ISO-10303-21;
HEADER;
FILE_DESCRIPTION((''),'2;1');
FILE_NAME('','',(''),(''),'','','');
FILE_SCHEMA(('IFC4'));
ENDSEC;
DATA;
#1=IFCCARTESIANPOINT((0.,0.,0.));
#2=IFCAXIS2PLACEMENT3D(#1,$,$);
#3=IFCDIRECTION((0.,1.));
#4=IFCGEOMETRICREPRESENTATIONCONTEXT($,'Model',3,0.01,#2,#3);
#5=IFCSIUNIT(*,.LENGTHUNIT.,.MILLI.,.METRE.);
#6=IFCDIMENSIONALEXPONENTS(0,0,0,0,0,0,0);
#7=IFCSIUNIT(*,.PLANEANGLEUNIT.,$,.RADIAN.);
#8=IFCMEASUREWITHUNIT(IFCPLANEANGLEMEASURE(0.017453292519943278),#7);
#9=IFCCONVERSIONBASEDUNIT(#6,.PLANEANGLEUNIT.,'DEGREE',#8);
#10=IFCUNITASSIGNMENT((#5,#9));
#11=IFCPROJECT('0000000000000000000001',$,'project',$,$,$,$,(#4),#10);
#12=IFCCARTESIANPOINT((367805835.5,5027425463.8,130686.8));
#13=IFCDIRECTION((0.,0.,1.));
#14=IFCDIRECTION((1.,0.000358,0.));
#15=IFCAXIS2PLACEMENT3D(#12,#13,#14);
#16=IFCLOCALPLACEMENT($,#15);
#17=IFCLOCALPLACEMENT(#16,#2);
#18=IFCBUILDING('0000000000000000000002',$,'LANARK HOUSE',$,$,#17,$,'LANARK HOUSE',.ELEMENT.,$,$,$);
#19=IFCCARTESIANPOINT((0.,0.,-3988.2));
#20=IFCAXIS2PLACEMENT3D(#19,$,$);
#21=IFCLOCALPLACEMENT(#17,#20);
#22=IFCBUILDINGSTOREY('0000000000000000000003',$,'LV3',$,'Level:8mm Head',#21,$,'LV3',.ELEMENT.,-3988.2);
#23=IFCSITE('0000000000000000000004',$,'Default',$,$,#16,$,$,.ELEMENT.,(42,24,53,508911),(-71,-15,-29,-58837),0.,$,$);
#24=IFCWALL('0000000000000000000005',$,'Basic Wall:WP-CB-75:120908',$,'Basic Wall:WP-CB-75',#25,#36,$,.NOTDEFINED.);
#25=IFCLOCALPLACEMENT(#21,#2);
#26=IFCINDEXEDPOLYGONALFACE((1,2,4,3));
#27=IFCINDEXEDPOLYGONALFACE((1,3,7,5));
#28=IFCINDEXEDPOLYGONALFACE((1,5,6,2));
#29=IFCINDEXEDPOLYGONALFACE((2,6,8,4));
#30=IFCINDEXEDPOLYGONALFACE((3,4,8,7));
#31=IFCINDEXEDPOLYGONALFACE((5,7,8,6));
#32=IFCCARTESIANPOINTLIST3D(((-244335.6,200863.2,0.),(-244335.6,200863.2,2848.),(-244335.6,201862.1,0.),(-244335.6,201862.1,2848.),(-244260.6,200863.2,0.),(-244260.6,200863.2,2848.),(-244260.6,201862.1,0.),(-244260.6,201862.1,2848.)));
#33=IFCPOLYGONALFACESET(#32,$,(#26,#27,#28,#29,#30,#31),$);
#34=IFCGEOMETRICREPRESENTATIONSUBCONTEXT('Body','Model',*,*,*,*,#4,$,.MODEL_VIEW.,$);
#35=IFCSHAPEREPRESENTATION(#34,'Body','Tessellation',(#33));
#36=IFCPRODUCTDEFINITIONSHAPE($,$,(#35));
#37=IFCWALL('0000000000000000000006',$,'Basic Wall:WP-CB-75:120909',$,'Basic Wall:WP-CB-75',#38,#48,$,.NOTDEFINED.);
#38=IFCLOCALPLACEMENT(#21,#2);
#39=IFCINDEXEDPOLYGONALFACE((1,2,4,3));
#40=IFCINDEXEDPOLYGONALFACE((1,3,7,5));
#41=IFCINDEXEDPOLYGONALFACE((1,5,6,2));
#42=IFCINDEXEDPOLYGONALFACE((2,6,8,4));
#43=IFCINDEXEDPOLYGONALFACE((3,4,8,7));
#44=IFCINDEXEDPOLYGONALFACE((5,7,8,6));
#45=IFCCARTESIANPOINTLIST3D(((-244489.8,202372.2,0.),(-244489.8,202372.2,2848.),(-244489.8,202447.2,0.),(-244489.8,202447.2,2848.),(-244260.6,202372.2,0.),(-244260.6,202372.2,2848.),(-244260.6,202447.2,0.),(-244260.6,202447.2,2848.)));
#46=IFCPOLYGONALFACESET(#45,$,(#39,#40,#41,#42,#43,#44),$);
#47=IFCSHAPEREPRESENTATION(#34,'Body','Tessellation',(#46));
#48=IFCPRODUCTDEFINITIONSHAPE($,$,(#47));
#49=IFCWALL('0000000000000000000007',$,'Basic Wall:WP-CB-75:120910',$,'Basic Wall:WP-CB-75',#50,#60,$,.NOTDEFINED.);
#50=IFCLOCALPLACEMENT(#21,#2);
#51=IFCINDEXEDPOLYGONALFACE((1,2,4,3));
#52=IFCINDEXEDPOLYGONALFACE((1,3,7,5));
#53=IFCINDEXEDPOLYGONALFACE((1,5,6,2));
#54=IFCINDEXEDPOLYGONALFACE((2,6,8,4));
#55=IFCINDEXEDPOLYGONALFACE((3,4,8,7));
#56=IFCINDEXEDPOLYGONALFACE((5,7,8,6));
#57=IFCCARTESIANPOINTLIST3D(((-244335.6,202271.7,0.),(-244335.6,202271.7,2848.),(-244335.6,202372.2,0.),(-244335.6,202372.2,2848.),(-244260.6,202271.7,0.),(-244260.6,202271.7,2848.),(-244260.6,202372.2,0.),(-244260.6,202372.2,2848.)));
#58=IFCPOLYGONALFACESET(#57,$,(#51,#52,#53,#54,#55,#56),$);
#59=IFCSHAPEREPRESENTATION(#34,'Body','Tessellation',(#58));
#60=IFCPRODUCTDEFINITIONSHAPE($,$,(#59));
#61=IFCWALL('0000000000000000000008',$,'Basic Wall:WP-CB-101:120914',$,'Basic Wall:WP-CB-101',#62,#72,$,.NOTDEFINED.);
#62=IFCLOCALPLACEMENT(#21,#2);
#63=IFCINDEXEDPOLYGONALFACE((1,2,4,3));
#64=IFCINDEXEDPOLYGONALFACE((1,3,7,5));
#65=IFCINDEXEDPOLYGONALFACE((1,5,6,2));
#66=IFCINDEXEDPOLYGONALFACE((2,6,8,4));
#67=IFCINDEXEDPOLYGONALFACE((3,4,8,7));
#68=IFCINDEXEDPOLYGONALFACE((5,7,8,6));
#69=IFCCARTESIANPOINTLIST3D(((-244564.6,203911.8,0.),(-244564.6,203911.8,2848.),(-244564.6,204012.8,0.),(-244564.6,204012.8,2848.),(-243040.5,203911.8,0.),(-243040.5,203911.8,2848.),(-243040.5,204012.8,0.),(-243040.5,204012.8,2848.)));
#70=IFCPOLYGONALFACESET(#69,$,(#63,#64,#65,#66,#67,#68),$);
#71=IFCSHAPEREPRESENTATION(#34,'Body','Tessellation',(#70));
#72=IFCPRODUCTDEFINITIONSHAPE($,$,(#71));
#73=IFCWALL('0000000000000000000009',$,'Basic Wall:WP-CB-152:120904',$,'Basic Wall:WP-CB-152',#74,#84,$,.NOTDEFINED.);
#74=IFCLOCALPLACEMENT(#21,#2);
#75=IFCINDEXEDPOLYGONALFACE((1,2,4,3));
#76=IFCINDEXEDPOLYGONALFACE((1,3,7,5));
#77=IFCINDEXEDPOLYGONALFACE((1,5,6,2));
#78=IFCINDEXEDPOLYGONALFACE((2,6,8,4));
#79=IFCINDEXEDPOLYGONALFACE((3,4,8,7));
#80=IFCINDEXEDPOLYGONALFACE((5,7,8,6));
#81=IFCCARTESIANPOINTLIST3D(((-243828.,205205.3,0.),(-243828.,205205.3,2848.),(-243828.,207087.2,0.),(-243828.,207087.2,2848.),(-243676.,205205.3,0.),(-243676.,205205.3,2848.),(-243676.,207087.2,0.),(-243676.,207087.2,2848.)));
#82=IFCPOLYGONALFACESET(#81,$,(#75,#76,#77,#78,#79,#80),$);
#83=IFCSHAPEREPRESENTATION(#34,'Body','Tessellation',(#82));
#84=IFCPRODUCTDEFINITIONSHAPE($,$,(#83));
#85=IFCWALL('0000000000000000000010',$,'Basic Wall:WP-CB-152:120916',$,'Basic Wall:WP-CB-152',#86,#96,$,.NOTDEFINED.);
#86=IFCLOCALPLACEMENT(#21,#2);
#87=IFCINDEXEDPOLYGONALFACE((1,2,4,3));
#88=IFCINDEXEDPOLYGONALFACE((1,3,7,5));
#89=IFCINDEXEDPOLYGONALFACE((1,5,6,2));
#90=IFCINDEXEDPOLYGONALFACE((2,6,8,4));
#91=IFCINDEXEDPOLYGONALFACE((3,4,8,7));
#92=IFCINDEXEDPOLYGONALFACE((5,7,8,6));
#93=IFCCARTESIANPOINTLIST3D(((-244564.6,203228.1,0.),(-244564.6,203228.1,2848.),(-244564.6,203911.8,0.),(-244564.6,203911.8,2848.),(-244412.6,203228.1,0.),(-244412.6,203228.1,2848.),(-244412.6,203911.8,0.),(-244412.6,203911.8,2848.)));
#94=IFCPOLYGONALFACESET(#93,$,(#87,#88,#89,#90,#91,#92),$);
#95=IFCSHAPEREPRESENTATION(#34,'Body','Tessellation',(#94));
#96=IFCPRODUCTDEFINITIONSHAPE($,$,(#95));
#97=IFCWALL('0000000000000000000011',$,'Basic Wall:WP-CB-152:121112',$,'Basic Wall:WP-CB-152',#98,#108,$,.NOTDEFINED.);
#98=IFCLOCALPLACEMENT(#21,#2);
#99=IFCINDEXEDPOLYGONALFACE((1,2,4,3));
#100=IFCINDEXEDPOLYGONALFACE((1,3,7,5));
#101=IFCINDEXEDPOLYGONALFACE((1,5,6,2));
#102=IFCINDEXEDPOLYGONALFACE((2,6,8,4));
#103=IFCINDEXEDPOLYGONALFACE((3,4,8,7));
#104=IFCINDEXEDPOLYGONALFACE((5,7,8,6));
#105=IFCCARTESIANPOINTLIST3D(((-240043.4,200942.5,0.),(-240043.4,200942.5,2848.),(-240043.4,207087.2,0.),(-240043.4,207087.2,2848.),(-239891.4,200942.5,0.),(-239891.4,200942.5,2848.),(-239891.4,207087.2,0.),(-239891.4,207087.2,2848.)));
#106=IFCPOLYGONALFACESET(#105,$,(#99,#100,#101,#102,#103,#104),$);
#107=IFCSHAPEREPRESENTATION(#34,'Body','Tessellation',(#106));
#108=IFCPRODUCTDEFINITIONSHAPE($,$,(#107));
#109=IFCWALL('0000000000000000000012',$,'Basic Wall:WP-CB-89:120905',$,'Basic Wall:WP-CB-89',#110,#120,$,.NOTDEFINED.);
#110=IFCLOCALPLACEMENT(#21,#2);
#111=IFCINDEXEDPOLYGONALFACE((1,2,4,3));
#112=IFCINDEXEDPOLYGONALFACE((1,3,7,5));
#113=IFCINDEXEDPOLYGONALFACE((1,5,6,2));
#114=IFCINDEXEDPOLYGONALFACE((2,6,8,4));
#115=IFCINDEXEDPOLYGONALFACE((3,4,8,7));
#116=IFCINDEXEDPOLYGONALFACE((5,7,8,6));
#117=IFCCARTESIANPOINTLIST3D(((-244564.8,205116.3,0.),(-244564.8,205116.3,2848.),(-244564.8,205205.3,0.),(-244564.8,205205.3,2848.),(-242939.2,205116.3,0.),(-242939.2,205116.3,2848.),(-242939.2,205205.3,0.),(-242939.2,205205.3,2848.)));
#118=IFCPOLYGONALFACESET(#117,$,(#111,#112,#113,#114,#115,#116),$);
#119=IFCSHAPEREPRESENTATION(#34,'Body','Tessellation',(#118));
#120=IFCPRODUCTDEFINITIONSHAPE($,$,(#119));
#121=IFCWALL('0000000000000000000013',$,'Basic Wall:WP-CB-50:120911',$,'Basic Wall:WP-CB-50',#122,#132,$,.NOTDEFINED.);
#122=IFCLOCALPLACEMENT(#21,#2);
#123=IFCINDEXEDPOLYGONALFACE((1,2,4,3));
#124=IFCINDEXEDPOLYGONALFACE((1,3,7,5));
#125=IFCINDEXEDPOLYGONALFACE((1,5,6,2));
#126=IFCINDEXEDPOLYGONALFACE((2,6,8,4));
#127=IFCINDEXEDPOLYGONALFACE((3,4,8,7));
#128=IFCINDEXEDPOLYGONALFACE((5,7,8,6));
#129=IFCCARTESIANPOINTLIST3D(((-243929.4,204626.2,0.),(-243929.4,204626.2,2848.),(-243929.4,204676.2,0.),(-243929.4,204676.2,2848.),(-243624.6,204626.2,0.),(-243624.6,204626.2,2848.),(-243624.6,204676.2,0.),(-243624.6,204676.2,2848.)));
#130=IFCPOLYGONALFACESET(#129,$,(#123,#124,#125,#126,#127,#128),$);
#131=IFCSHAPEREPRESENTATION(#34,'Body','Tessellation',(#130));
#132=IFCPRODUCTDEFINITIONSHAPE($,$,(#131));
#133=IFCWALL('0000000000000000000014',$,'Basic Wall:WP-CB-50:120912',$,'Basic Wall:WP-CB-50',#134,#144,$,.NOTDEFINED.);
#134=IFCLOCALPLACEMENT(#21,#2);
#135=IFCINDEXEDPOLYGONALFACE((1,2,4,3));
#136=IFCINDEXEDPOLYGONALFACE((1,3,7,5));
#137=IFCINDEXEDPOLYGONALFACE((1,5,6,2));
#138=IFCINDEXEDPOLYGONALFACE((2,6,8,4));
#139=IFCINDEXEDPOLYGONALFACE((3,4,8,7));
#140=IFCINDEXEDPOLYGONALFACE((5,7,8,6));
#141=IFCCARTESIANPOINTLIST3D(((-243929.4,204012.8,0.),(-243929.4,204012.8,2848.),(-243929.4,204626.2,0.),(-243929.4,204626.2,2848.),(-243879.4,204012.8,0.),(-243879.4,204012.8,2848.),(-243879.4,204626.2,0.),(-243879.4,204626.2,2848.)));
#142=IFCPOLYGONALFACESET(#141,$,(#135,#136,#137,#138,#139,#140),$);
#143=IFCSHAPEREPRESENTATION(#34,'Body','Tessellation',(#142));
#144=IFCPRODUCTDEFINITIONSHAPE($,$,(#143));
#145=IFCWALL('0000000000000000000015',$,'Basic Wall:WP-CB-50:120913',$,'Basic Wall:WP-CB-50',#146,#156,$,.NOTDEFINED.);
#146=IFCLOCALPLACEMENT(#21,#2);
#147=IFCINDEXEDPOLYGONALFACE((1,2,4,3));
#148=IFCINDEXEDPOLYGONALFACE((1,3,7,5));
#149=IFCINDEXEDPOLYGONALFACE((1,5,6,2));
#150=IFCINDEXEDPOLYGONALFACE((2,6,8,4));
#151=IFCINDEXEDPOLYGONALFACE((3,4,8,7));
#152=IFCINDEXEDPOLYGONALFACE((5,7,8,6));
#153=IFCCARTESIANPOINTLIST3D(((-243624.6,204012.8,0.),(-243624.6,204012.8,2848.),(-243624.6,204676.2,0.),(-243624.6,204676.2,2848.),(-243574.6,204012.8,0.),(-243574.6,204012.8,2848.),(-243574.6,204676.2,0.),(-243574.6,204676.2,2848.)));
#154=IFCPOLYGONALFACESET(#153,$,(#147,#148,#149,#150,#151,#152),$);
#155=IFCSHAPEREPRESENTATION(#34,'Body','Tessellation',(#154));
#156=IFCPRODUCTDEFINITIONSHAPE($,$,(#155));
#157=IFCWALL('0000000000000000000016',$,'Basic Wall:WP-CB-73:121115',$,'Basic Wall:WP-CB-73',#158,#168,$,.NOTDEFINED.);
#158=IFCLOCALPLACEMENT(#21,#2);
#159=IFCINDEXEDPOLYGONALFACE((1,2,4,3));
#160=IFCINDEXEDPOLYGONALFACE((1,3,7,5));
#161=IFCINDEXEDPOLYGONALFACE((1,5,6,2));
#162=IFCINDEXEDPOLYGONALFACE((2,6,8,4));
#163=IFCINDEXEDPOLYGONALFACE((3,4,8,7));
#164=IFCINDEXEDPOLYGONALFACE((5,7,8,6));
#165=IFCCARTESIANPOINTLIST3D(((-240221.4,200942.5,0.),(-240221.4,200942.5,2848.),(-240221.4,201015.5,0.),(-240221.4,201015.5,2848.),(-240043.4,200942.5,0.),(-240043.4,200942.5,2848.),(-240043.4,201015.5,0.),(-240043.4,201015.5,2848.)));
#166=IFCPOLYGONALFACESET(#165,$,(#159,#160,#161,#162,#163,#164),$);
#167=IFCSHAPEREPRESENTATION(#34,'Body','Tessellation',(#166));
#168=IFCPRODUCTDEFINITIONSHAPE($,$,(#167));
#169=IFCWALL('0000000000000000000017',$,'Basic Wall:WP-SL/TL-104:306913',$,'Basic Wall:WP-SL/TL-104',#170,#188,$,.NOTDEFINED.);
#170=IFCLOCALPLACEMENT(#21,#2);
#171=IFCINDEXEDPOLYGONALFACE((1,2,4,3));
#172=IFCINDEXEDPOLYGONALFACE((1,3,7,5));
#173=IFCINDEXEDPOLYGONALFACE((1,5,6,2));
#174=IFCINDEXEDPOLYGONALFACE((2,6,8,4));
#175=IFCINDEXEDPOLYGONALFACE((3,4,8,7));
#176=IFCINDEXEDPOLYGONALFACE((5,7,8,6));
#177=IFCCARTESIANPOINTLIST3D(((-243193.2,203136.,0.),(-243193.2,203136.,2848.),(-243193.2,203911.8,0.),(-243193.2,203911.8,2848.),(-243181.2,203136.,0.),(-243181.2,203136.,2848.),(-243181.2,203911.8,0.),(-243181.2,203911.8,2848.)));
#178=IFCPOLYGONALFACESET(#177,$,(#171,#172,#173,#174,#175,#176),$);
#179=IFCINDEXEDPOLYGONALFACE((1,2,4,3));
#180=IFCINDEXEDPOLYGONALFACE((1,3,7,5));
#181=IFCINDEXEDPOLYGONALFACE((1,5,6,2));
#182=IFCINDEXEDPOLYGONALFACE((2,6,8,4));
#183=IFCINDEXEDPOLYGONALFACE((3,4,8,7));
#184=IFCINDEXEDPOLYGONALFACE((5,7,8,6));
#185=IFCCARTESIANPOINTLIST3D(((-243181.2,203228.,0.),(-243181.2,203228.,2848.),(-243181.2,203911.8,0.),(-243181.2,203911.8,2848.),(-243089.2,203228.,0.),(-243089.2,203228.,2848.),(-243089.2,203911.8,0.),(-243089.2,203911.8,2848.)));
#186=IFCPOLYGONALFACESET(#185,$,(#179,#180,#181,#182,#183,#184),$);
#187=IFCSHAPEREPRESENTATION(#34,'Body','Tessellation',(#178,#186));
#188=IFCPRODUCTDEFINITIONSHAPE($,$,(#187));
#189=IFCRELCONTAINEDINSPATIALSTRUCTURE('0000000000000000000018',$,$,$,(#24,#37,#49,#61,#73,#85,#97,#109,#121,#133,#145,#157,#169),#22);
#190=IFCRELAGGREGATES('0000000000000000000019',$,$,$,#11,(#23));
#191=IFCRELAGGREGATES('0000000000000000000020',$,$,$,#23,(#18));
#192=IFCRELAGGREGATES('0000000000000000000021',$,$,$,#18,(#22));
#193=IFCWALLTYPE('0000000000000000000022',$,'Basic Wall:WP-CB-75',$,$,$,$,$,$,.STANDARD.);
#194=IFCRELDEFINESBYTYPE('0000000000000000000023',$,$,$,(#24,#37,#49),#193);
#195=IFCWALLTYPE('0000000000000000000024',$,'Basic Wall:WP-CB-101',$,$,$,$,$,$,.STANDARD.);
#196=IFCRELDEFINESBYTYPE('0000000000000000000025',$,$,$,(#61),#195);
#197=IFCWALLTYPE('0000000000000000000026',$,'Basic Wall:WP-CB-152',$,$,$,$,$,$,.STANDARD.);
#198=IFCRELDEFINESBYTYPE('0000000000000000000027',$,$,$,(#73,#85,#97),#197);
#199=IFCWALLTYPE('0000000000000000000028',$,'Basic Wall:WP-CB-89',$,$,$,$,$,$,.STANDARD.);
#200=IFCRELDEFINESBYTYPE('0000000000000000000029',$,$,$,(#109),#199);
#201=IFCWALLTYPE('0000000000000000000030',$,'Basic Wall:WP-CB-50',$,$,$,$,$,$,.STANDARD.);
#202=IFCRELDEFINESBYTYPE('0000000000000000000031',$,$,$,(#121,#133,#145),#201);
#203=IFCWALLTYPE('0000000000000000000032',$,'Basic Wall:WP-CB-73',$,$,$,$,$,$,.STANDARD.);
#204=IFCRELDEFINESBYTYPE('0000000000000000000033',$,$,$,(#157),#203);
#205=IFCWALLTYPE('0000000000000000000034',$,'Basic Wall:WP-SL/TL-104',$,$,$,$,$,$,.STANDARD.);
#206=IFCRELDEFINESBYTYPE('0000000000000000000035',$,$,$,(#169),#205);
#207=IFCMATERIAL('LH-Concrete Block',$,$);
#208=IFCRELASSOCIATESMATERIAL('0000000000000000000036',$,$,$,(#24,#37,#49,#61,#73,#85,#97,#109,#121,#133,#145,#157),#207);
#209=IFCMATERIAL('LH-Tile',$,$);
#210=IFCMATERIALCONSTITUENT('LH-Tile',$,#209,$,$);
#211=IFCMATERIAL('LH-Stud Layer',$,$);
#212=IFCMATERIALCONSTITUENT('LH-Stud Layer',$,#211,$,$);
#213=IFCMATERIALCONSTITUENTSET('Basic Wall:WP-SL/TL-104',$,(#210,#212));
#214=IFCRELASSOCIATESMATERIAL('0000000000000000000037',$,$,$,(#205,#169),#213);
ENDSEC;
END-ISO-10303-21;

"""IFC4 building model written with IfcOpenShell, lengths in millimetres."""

from ifc_helpers import new_model, entity, si_unit, converted_unit, direction, frame, origin, place, context, subcontext, project, spatial, indexed_curve, outline, extrude, material, constituent, constituent_set, type_object, element, save


model = new_model("IFC4")

# Units and contexts
model_context = context("Model", 3, precision=0.01, world=origin(), true_north=direction((0.0, 1.0)))
body_context = subcontext(model_context, "Body", "Model", "MODEL_VIEW")
ifc_project = project(units=[si_unit("LENGTHUNIT", "METRE", prefix="MILLI"), converted_unit("PLANEANGLEUNIT", "DEGREE", entity("IfcPlaneAngleMeasure", 0.017453292519943278), si_unit("PLANEANGLEUNIT", "RADIAN"), dimensions=[0, 0, 0, 0, 0, 0, 0])], contexts=[model_context])

# Site, building, storey
site_placement = place(None, frame((367805835.5, 5027425463.8, 130686.8), z_axis=(0.0, 0.0, 1.0), x_axis=(1.0, 0.000358, 0.0)))
site = spatial("IfcSite", under=ifc_project, at=site_placement, Name="Default", CompositionType="ELEMENT", RefLatitude=(42, 24, 53, 508911), RefLongitude=(-71, -15, -29, -58837), RefElevation=0.0)
building_placement = place(site_placement, origin())
building = spatial("IfcBuilding", under=site, at=building_placement, Name="LANARK HOUSE", LongName="LANARK HOUSE", CompositionType="ELEMENT")
storey_placement = place(building_placement, frame((0.0, 0.0, -3988.2)))
storey = spatial("IfcBuildingStorey", under=building, at=storey_placement, Name="LV3", ObjectType="Level:8mm Head", LongName="LV3", CompositionType="ELEMENT", Elevation=-3988.2)

# Walls
ifc_material_1 = material(Name="LH-Concrete Block")
wall_type_1 = type_object("IfcWallType", Name="Basic Wall:WP-CB-75", PredefinedType="STANDARD")
wall_1_placement = place(storey_placement, frame((-244298.1, 200863.2, 0.0), z_axis=(0.0, 0.0, 1.0), x_axis=(0.0, 1.0, 0.0)))
element("IfcWall", 1, at=wall_1_placement, inside=storey, type_object=wall_type_1, material=ifc_material_1, Name="Basic Wall:WP-CB-75:120908", ObjectType="Basic Wall:WP-CB-75", PredefinedType="NOTDEFINED", context=body_context, shape_type="SweptSolid", body=[
    extrude(outline(indexed_curve([(998.9, 37.5), (0.0, 37.5), (0.0, -37.5), (998.9, -37.5), (998.9, 37.5)], self_intersect=False)), origin(), (0.0, 0.0, 1.0), 2848.0),
])
wall_2_placement = place(storey_placement, frame((-244489.8, 202409.7, 0.0)))
element("IfcWall", 2, at=wall_2_placement, inside=storey, type_object=wall_type_1, material=ifc_material_1, Name="Basic Wall:WP-CB-75:120909", ObjectType="Basic Wall:WP-CB-75", PredefinedType="NOTDEFINED", context=body_context, shape_type="SweptSolid", body=[
    extrude(outline(indexed_curve([(229.2, 37.5), (0.0, 37.5), (0.0, -37.5), (229.2, -37.5), (229.2, 37.5)], self_intersect=False)), origin(), (0.0, 0.0, 1.0), 2848.0),
])
wall_3_placement = place(storey_placement, frame((-244298.1, 202372.2, 0.0), z_axis=(0.0, 0.0, 1.0), x_axis=(0.0, -1.0, 0.0)))
element("IfcWall", 3, at=wall_3_placement, inside=storey, type_object=wall_type_1, material=ifc_material_1, Name="Basic Wall:WP-CB-75:120910", ObjectType="Basic Wall:WP-CB-75", PredefinedType="NOTDEFINED", context=body_context, shape_type="SweptSolid", body=[
    extrude(outline(indexed_curve([(100.5, 37.5), (0.0, 37.5), (0.0, -37.5), (100.5, -37.5), (100.5, 37.5)], self_intersect=False)), origin(), (0.0, 0.0, 1.0), 2848.0),
])
wall_type_2 = type_object("IfcWallType", Name="Basic Wall:WP-CB-101", PredefinedType="STANDARD")
wall_4_placement = place(storey_placement, frame((-243040.5, 203962.3, 0.0), z_axis=(0.0, 0.0, 1.0), x_axis=(-1.0, 0.0, 0.0)))
element("IfcWall", 4, at=wall_4_placement, inside=storey, type_object=wall_type_2, material=ifc_material_1, Name="Basic Wall:WP-CB-101:120914", ObjectType="Basic Wall:WP-CB-101", PredefinedType="NOTDEFINED", context=body_context, shape_type="SweptSolid", body=[
    extrude(outline(indexed_curve([(1524.1, 50.5), (0.0, 50.5), (0.0, -50.5), (1524.1, -50.5), (1524.1, 50.5)], self_intersect=False)), origin(), (0.0, 0.0, 1.0), 2848.0),
])
wall_type_3 = type_object("IfcWallType", Name="Basic Wall:WP-CB-152", PredefinedType="STANDARD")
wall_5_placement = place(storey_placement, frame((-243752.0, 205205.3, 0.0), z_axis=(0.0, 0.0, 1.0), x_axis=(0.0, 1.0, 0.0)))
element("IfcWall", 5, at=wall_5_placement, inside=storey, type_object=wall_type_3, material=ifc_material_1, Name="Basic Wall:WP-CB-152:120904", ObjectType="Basic Wall:WP-CB-152", PredefinedType="NOTDEFINED", context=body_context, shape_type="SweptSolid", body=[
    extrude(outline(indexed_curve([(1881.9, 76.0), (0.0, 76.0), (0.0, -76.0), (1881.9, -76.0), (1881.9, 76.0)], self_intersect=False)), origin(), (0.0, 0.0, 1.0), 2848.0),
])
wall_6_placement = place(storey_placement, frame((-244488.6, 203228.1, 0.0), z_axis=(0.0, 0.0, 1.0), x_axis=(0.0, 1.0, 0.0)))
element("IfcWall", 6, at=wall_6_placement, inside=storey, type_object=wall_type_3, material=ifc_material_1, Name="Basic Wall:WP-CB-152:120916", ObjectType="Basic Wall:WP-CB-152", PredefinedType="NOTDEFINED", context=body_context, shape_type="SweptSolid", body=[
    extrude(outline(indexed_curve([(683.7, 76.0), (0.0, 76.0), (0.0, -76.0), (683.7, -76.0), (683.7, 76.0)], self_intersect=False)), origin(), (0.0, 0.0, 1.0), 2848.0),
])
wall_7_placement = place(storey_placement, frame((-239967.4, 207087.2, 0.0), z_axis=(0.0, 0.0, 1.0), x_axis=(0.0, -1.0, 0.0)))
element("IfcWall", 7, at=wall_7_placement, inside=storey, type_object=wall_type_3, material=ifc_material_1, Name="Basic Wall:WP-CB-152:121112", ObjectType="Basic Wall:WP-CB-152", PredefinedType="NOTDEFINED", context=body_context, shape_type="SweptSolid", body=[
    extrude(outline(indexed_curve([(6144.8, 76.0), (0.0, 76.0), (0.0, -76.0), (6144.8, -76.0), (6144.8, 76.0)], self_intersect=False)), origin(), (0.0, 0.0, 1.0), 2848.0),
])
wall_type_4 = type_object("IfcWallType", Name="Basic Wall:WP-CB-89", PredefinedType="STANDARD")
wall_8_placement = place(storey_placement, frame((-242939.2, 205160.8, 0.0), z_axis=(0.0, 0.0, 1.0), x_axis=(-1.0, 0.0, 0.0)))
element("IfcWall", 8, at=wall_8_placement, inside=storey, type_object=wall_type_4, material=ifc_material_1, Name="Basic Wall:WP-CB-89:120905", ObjectType="Basic Wall:WP-CB-89", PredefinedType="NOTDEFINED", context=body_context, shape_type="SweptSolid", body=[
    extrude(outline(indexed_curve([(1625.6, 44.5), (0.0, 44.5), (0.0, -44.5), (1625.6, -44.5), (1625.6, 44.5)], self_intersect=False)), origin(), (0.0, 0.0, 1.0), 2848.0),
])
wall_type_5 = type_object("IfcWallType", Name="Basic Wall:WP-CB-50", PredefinedType="STANDARD")
wall_9_placement = place(storey_placement, frame((-243929.4, 204651.2, 0.0)))
element("IfcWall", 9, at=wall_9_placement, inside=storey, type_object=wall_type_5, material=ifc_material_1, Name="Basic Wall:WP-CB-50:120911", ObjectType="Basic Wall:WP-CB-50", PredefinedType="NOTDEFINED", context=body_context, shape_type="SweptSolid", body=[
    extrude(outline(indexed_curve([(304.8, 25.0), (0.0, 25.0), (0.0, -25.0), (304.8, -25.0), (304.8, 25.0)], self_intersect=False)), origin(), (0.0, 0.0, 1.0), 2848.0),
])
wall_10_placement = place(storey_placement, frame((-243904.4, 204012.8, 0.0), z_axis=(0.0, 0.0, 1.0), x_axis=(0.0, 1.0, 0.0)))
element("IfcWall", 10, at=wall_10_placement, inside=storey, type_object=wall_type_5, material=ifc_material_1, Name="Basic Wall:WP-CB-50:120912", ObjectType="Basic Wall:WP-CB-50", PredefinedType="NOTDEFINED", context=body_context, shape_type="SweptSolid", body=[
    extrude(outline(indexed_curve([(613.5, 25.0), (0.0, 25.0), (0.0, -25.0), (613.5, -25.0), (613.5, 25.0)], self_intersect=False)), origin(), (0.0, 0.0, 1.0), 2848.0),
])
wall_11_placement = place(storey_placement, frame((-243599.6, 204012.8, 0.0), z_axis=(0.0, 0.0, 1.0), x_axis=(0.0, 1.0, 0.0)))
element("IfcWall", 11, at=wall_11_placement, inside=storey, type_object=wall_type_5, material=ifc_material_1, Name="Basic Wall:WP-CB-50:120913", ObjectType="Basic Wall:WP-CB-50", PredefinedType="NOTDEFINED", context=body_context, shape_type="SweptSolid", body=[
    extrude(outline(indexed_curve([(663.5, 25.0), (0.0, 25.0), (0.0, -25.0), (663.5, -25.0), (663.5, 25.0)], self_intersect=False)), origin(), (0.0, 0.0, 1.0), 2848.0),
])
wall_type_6 = type_object("IfcWallType", Name="Basic Wall:WP-CB-73", PredefinedType="STANDARD")
wall_12_placement = place(storey_placement, frame((-240221.4, 200979.0, 0.0)))
element("IfcWall", 12, at=wall_12_placement, inside=storey, type_object=wall_type_6, material=ifc_material_1, Name="Basic Wall:WP-CB-73:121115", ObjectType="Basic Wall:WP-CB-73", PredefinedType="NOTDEFINED", context=body_context, shape_type="SweptSolid", body=[
    extrude(outline(indexed_curve([(178.1, 36.5), (0.0, 36.5), (0.0, -36.5), (178.1, -36.5), (178.1, 36.5)], self_intersect=False)), origin(), (0.0, 0.0, 1.0), 2848.0),
])
ifc_material_2 = material(Name="LH-Tile")
ifc_constituent_1 = constituent(ifc_material_2, Name="LH-Tile")
ifc_material_3 = material(Name="LH-Stud Layer")
ifc_constituent_2 = constituent(ifc_material_3, Name="LH-Stud Layer")
ifc_constituent_set_1 = constituent_set(constituents=[ifc_constituent_1, ifc_constituent_2], Name="Basic Wall:WP-SL/TL-104")
wall_type_7 = type_object("IfcWallType", Name="Basic Wall:WP-SL/TL-104", PredefinedType="STANDARD", material=ifc_constituent_set_1)
wall_13_placement = place(storey_placement, frame((-243141.2, 203228.0, 0.0), z_axis=(0.0, 0.0, 1.0), x_axis=(0.0, 1.0, 0.0)))
element("IfcWall", 13, at=wall_13_placement, inside=storey, type_object=wall_type_7, material=ifc_constituent_set_1, Name="Basic Wall:WP-SL/TL-104:306913", ObjectType="Basic Wall:WP-SL/TL-104", PredefinedType="NOTDEFINED", context=body_context, shape_type="SweptSolid", body=[
    extrude(outline(indexed_curve([(-6.0, -387.9), (6.0, -387.9), (6.0, 387.9), (-6.0, 387.9), (-6.0, -387.9)], self_intersect=False)), frame((295.9, 46.0, 0.0), z_axis=(0.0, 0.0, 1.0), x_axis=(0.0, -1.0, 0.0)), (0.0, 0.0, 1.0), 2848.0),
    extrude(outline(indexed_curve([(-46.0, -341.9), (46.0, -341.9), (46.0, 341.9), (-46.0, 341.9), (-46.0, -341.9)], self_intersect=False)), frame((341.9, -6.0, 0.0), z_axis=(0.0, 0.0, 1.0), x_axis=(0.0, 1.0, 0.0)), (0.0, 0.0, 1.0), 2848.0),
])

save(model, "model.ifc")
